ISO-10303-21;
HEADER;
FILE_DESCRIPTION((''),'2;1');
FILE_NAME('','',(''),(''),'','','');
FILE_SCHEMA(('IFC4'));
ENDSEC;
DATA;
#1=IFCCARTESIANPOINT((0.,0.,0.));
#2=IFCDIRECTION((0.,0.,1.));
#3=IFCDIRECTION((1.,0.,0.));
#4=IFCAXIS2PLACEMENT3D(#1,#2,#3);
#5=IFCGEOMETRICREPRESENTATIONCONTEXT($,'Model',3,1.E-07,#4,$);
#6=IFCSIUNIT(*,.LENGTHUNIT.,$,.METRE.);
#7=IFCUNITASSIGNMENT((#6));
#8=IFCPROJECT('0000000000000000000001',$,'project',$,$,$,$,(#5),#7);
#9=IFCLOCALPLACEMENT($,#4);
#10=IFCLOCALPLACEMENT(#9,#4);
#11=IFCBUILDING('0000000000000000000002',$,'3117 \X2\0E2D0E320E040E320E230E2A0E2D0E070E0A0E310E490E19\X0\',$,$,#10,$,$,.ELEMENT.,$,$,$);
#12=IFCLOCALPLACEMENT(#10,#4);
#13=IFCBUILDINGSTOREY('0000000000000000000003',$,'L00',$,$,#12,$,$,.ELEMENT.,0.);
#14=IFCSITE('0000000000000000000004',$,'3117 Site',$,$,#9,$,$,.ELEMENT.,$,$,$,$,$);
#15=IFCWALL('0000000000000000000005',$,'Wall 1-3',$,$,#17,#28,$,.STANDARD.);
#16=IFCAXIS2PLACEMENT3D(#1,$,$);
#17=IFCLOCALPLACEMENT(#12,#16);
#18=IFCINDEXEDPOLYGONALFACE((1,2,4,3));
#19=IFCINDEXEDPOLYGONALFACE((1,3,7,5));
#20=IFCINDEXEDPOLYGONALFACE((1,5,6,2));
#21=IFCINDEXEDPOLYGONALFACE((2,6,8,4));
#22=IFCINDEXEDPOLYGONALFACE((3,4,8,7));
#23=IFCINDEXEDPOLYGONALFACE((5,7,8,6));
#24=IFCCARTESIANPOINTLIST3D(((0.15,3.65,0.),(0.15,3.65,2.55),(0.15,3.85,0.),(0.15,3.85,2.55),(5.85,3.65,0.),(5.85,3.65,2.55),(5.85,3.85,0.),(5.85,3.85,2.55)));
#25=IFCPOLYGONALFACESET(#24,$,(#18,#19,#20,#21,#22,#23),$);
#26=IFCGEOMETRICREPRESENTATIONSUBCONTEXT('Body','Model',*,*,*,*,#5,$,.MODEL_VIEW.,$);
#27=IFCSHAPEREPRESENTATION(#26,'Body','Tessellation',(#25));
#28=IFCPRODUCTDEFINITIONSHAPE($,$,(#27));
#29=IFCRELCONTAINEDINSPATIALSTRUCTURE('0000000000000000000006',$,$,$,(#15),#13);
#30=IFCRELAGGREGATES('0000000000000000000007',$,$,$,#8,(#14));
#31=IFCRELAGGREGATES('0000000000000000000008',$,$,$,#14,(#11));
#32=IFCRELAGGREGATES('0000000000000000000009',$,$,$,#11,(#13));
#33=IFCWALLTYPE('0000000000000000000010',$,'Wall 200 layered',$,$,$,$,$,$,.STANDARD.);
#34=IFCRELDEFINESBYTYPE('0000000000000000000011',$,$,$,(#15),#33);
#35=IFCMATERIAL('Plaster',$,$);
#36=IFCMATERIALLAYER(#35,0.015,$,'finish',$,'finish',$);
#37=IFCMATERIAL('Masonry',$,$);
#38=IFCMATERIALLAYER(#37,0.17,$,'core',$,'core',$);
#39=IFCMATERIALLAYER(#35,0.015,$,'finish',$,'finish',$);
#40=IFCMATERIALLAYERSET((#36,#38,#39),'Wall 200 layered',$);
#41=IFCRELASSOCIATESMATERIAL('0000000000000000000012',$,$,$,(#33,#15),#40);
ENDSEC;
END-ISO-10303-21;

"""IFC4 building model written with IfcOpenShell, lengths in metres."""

from ifc_helpers import new_model, si_unit, frame, origin_with_axes, place, context, subcontext, project, spatial, polyline, outline, extrude, material, layer, layer_set, layer_usage, type_object, element, save


model = new_model("IFC4")

# Units and contexts
model_context = context("Model", 3, precision=1e-07, world=origin_with_axes())
body_context = subcontext(model_context, "Body", "Model", "MODEL_VIEW")
ifc_project = project(units=[si_unit("LENGTHUNIT", "METRE")], contexts=[model_context])

# Site, building, storey
site_placement = place(None, origin_with_axes())
site = spatial("IfcSite", under=ifc_project, at=site_placement, Name="3117 Site", CompositionType="ELEMENT")
building_placement = place(site_placement, origin_with_axes())
building = spatial("IfcBuilding", under=site, at=building_placement, Name="3117 อาคารสองชั้น", CompositionType="ELEMENT")
storey_placement = place(building_placement, origin_with_axes())
storey = spatial("IfcBuildingStorey", under=building, at=storey_placement, Name="L00", CompositionType="ELEMENT", Elevation=0.0)

# Shared definitions
ifc_material_1 = material(Name="Plaster")
ifc_layer_1 = layer(ifc_material_1, 0.015, Name="finish", Category="finish")
ifc_material_2 = material(Name="Masonry")
ifc_layer_2 = layer(ifc_material_2, 0.17, Name="core", Category="core")
ifc_layer_3 = layer(ifc_material_1, 0.015, Name="finish", Category="finish")
ifc_layer_set_1 = layer_set([ifc_layer_1, ifc_layer_2, ifc_layer_3], Name="Wall 200 layered")
wall_type = type_object("IfcWallType", Name="Wall 200 layered", PredefinedType="STANDARD", material=ifc_layer_set_1)

# Wall
ifc_layer_usage_1 = layer_usage(ifc_layer_set_1, "AXIS2", "POSITIVE", 0.0)
wall_1_placement = place(storey_placement, frame((5.85, 3.85, 0.0), z_axis=(0.0, 0.0, 1.0), x_axis=(-1.0, 0.0, 0.0)))
element("IfcWall", 1, at=wall_1_placement, inside=storey, type_object=wall_type, material=ifc_layer_usage_1, Name="Wall 1-3", PredefinedType="STANDARD", context=body_context, shape_type="SweptSolid", body=[
    extrude(outline(polyline([(0.0, 0.0), (5.7, 0.0), (5.7, 0.2), (0.0, 0.2), (0.0, 0.0)])), origin_with_axes(), (0.0, 0.0, 1.0), 2.55),
])

save(model, "model.ifc")
